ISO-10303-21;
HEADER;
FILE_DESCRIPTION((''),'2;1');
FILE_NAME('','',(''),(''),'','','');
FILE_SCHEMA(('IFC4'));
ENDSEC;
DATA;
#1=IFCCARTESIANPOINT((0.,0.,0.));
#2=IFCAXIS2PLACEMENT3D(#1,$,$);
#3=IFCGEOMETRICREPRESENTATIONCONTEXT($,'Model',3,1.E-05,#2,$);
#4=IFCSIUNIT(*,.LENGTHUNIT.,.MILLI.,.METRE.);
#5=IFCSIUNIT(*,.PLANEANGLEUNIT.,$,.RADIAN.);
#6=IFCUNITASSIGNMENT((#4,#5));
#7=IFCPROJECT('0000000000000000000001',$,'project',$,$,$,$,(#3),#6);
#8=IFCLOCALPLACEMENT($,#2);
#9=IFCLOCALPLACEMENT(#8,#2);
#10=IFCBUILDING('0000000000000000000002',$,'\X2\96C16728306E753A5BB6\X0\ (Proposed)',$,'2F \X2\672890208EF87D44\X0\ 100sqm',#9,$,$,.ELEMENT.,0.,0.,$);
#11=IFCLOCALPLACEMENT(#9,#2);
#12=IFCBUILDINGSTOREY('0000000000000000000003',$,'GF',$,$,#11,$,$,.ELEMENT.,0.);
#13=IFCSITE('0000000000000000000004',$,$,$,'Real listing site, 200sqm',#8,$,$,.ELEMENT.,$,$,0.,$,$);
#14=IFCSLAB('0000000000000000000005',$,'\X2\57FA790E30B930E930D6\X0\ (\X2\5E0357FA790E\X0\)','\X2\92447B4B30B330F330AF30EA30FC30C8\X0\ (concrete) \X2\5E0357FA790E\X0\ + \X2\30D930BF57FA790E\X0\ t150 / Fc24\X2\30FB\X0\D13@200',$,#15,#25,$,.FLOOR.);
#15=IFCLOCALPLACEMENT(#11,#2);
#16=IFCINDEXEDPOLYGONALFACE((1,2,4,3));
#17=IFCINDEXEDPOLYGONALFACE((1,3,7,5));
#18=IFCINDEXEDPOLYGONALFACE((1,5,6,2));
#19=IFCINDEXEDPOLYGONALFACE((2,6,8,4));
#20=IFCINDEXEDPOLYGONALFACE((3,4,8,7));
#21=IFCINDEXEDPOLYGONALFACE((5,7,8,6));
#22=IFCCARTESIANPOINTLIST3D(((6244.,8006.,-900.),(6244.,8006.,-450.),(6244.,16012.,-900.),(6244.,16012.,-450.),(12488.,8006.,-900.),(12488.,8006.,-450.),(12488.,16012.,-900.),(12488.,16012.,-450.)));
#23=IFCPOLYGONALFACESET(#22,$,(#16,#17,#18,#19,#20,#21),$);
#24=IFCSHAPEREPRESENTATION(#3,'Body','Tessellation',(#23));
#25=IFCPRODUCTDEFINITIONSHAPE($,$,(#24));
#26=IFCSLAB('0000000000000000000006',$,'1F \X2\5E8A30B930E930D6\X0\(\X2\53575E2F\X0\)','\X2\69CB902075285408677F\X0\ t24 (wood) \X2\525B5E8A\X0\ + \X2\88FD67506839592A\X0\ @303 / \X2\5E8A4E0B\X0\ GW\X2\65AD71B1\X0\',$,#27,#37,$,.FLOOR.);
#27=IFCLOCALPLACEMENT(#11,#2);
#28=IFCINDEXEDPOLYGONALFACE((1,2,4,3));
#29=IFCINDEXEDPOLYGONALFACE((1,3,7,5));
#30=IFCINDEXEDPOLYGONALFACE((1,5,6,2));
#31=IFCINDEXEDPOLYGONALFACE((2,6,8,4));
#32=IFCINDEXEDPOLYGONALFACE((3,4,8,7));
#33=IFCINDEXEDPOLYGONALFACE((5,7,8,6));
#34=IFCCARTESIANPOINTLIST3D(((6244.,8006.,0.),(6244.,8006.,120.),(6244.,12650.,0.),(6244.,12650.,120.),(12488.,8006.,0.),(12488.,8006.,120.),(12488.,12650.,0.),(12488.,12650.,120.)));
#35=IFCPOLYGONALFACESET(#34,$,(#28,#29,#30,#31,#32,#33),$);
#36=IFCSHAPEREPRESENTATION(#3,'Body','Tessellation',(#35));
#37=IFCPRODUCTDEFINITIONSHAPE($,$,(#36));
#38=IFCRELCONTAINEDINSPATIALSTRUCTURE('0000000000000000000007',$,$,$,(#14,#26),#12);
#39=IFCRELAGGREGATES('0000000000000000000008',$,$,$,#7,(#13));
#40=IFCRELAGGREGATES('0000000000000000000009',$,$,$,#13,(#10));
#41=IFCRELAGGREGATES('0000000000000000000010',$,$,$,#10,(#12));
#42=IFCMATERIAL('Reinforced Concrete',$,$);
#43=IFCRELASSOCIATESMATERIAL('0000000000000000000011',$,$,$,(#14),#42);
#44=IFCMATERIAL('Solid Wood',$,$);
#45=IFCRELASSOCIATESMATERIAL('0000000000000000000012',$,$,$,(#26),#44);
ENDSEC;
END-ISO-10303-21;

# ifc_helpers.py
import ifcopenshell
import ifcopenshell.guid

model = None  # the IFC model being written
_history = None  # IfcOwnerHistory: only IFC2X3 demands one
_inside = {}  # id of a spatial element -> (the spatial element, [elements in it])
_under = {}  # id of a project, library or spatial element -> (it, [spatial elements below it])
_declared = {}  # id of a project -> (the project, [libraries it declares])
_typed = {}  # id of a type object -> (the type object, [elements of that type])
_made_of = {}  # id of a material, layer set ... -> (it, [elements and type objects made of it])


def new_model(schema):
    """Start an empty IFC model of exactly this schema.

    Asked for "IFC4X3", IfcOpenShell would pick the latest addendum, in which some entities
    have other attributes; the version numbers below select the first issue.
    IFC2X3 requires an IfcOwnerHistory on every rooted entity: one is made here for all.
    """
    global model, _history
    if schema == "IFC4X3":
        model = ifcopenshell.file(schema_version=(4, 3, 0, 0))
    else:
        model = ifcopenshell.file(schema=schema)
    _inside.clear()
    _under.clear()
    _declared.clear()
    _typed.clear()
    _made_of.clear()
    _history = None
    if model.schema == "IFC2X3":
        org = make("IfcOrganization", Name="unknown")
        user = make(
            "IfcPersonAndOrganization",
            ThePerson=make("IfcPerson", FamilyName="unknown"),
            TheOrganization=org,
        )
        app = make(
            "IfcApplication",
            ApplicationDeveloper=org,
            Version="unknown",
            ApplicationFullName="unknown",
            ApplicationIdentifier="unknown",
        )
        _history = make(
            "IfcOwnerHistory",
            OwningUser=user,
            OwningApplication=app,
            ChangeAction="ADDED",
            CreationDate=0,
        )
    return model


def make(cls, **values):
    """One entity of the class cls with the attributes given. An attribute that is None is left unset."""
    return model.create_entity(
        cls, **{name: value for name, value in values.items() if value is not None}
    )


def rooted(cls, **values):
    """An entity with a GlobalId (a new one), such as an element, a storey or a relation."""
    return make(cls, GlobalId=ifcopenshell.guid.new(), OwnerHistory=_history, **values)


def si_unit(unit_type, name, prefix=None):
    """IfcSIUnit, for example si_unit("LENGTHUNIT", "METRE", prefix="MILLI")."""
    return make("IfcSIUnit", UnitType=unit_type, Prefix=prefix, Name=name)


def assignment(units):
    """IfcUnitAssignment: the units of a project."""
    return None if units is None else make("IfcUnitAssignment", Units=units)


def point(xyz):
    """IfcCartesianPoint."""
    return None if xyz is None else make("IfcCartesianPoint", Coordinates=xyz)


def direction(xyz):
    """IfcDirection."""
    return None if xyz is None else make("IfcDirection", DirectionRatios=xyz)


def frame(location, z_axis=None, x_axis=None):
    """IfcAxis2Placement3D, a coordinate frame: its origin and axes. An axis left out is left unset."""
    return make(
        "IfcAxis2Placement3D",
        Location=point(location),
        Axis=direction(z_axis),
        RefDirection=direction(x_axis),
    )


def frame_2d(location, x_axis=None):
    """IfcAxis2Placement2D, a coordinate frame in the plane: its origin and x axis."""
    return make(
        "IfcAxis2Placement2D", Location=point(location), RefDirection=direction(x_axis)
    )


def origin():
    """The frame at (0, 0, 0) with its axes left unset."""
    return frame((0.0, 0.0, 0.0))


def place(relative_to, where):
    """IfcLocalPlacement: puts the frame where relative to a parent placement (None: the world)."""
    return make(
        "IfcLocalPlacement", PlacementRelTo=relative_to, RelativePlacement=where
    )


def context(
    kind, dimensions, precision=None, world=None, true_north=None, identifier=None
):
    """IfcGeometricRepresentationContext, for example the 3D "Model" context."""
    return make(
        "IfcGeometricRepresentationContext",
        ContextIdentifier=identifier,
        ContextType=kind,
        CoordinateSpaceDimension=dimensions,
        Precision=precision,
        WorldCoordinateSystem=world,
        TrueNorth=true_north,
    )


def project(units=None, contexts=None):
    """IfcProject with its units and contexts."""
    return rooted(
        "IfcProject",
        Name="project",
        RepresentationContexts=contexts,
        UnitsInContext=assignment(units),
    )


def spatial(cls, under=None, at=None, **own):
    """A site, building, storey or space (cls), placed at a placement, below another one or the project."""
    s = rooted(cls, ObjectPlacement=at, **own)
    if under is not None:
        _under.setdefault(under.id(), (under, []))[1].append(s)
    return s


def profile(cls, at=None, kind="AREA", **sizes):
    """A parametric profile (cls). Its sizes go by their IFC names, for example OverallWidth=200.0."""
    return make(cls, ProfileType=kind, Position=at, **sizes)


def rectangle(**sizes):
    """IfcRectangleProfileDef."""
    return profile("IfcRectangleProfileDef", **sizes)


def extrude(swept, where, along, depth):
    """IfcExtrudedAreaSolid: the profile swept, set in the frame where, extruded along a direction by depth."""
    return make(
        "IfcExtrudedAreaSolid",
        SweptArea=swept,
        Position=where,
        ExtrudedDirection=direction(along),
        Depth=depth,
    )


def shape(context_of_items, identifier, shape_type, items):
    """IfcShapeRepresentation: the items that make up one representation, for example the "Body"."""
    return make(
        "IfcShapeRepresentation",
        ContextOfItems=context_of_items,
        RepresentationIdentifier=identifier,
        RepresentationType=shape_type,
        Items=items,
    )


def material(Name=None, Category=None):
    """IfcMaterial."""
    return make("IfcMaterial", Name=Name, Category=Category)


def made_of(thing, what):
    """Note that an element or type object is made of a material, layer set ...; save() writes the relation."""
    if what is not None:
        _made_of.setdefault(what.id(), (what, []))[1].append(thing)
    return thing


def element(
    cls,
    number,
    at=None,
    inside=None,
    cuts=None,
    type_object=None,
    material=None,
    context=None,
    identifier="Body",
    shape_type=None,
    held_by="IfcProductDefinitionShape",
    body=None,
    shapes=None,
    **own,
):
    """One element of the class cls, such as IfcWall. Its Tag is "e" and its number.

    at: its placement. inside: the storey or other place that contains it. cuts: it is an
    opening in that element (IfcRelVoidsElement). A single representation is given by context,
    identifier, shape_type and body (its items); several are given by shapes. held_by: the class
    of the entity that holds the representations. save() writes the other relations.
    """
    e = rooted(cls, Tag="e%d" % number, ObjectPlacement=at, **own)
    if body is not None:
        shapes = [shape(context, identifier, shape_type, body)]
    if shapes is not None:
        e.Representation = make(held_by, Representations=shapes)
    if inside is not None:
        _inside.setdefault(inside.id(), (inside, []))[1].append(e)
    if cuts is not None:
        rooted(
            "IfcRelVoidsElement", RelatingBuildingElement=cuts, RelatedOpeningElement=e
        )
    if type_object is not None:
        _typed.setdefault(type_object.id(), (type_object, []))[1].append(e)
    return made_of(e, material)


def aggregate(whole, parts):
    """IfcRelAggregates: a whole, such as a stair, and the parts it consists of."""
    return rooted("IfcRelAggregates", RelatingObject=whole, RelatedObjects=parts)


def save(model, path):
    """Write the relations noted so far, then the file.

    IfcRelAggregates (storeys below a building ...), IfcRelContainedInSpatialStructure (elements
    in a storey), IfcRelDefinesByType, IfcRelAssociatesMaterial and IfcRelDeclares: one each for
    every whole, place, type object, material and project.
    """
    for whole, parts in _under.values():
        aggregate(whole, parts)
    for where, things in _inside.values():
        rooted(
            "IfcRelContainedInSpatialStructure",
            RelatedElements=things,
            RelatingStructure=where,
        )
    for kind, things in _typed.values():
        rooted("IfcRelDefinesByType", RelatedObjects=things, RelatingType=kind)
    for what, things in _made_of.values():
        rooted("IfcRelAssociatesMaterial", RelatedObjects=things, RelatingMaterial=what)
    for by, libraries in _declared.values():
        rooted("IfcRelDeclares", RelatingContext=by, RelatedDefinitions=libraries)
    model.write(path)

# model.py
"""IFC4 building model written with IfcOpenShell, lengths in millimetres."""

from ifc_helpers import new_model, si_unit, frame, frame_2d, origin, place, context, project, spatial, rectangle, extrude, material, element, save


model = new_model("IFC4")

# Units and contexts
model_context = context("Model", 3, precision=1e-05, world=origin())
ifc_project = project(units=[si_unit("LENGTHUNIT", "METRE", prefix="MILLI"), si_unit("PLANEANGLEUNIT", "RADIAN")], contexts=[model_context])

# Site, building, storey
site_placement = place(None, origin())
site = spatial("IfcSite", under=ifc_project, at=site_placement, ObjectType="Real listing site, 200sqm", CompositionType="ELEMENT", RefElevation=0.0)
building_placement = place(site_placement, origin())
building = spatial("IfcBuilding", under=site, at=building_placement, Name="雁木の町家 (Proposed)", ObjectType="2F 木造軸組 100sqm", CompositionType="ELEMENT", ElevationOfRefHeight=0.0, ElevationOfTerrain=0.0)
storey_placement = place(building_placement, origin())
storey = spatial("IfcBuildingStorey", under=building, at=storey_placement, Name="GF", CompositionType="ELEMENT", Elevation=0.0)

# Slabs
ifc_material_1 = material(Name="Reinforced Concrete")
slab_1_placement = place(storey_placement, frame((3122.0, 4003.0, -450.0)))
element("IfcSlab", 1, at=slab_1_placement, inside=storey, material=ifc_material_1, Name="基礎スラブ (布基礎)", Description="鉄筋コンクリート (concrete) 布基礎 + ベタ基礎 t150 / Fc24・D13@200", PredefinedType="FLOOR", context=model_context, shape_type="SweptSolid", body=[
    extrude(rectangle(XDim=6244.0, YDim=8006.0, at=frame_2d((3122.0, 4003.0))), frame((3122.0, 4003.0, -450.0)), (0.0, 0.0, 1.0), 450.0),
])
ifc_material_2 = material(Name="Solid Wood")
slab_2_placement = place(storey_placement, frame((3122.0, 4003.0, 0.0)))
element("IfcSlab", 2, at=slab_2_placement, inside=storey, material=ifc_material_2, Name="1F 床スラブ(南帯)", Description="構造用合板 t24 (wood) 剛床 + 製材根太 @303 / 床下 GW断熱", PredefinedType="FLOOR", context=model_context, shape_type="SweptSolid", body=[
    extrude(rectangle(XDim=6244.0, YDim=4644.0, at=frame_2d((3122.0, 2322.0))), frame((3122.0, 4003.0, 0.0)), (0.0, 0.0, 1.0), 120.0),
])

save(model, "model.ifc")
